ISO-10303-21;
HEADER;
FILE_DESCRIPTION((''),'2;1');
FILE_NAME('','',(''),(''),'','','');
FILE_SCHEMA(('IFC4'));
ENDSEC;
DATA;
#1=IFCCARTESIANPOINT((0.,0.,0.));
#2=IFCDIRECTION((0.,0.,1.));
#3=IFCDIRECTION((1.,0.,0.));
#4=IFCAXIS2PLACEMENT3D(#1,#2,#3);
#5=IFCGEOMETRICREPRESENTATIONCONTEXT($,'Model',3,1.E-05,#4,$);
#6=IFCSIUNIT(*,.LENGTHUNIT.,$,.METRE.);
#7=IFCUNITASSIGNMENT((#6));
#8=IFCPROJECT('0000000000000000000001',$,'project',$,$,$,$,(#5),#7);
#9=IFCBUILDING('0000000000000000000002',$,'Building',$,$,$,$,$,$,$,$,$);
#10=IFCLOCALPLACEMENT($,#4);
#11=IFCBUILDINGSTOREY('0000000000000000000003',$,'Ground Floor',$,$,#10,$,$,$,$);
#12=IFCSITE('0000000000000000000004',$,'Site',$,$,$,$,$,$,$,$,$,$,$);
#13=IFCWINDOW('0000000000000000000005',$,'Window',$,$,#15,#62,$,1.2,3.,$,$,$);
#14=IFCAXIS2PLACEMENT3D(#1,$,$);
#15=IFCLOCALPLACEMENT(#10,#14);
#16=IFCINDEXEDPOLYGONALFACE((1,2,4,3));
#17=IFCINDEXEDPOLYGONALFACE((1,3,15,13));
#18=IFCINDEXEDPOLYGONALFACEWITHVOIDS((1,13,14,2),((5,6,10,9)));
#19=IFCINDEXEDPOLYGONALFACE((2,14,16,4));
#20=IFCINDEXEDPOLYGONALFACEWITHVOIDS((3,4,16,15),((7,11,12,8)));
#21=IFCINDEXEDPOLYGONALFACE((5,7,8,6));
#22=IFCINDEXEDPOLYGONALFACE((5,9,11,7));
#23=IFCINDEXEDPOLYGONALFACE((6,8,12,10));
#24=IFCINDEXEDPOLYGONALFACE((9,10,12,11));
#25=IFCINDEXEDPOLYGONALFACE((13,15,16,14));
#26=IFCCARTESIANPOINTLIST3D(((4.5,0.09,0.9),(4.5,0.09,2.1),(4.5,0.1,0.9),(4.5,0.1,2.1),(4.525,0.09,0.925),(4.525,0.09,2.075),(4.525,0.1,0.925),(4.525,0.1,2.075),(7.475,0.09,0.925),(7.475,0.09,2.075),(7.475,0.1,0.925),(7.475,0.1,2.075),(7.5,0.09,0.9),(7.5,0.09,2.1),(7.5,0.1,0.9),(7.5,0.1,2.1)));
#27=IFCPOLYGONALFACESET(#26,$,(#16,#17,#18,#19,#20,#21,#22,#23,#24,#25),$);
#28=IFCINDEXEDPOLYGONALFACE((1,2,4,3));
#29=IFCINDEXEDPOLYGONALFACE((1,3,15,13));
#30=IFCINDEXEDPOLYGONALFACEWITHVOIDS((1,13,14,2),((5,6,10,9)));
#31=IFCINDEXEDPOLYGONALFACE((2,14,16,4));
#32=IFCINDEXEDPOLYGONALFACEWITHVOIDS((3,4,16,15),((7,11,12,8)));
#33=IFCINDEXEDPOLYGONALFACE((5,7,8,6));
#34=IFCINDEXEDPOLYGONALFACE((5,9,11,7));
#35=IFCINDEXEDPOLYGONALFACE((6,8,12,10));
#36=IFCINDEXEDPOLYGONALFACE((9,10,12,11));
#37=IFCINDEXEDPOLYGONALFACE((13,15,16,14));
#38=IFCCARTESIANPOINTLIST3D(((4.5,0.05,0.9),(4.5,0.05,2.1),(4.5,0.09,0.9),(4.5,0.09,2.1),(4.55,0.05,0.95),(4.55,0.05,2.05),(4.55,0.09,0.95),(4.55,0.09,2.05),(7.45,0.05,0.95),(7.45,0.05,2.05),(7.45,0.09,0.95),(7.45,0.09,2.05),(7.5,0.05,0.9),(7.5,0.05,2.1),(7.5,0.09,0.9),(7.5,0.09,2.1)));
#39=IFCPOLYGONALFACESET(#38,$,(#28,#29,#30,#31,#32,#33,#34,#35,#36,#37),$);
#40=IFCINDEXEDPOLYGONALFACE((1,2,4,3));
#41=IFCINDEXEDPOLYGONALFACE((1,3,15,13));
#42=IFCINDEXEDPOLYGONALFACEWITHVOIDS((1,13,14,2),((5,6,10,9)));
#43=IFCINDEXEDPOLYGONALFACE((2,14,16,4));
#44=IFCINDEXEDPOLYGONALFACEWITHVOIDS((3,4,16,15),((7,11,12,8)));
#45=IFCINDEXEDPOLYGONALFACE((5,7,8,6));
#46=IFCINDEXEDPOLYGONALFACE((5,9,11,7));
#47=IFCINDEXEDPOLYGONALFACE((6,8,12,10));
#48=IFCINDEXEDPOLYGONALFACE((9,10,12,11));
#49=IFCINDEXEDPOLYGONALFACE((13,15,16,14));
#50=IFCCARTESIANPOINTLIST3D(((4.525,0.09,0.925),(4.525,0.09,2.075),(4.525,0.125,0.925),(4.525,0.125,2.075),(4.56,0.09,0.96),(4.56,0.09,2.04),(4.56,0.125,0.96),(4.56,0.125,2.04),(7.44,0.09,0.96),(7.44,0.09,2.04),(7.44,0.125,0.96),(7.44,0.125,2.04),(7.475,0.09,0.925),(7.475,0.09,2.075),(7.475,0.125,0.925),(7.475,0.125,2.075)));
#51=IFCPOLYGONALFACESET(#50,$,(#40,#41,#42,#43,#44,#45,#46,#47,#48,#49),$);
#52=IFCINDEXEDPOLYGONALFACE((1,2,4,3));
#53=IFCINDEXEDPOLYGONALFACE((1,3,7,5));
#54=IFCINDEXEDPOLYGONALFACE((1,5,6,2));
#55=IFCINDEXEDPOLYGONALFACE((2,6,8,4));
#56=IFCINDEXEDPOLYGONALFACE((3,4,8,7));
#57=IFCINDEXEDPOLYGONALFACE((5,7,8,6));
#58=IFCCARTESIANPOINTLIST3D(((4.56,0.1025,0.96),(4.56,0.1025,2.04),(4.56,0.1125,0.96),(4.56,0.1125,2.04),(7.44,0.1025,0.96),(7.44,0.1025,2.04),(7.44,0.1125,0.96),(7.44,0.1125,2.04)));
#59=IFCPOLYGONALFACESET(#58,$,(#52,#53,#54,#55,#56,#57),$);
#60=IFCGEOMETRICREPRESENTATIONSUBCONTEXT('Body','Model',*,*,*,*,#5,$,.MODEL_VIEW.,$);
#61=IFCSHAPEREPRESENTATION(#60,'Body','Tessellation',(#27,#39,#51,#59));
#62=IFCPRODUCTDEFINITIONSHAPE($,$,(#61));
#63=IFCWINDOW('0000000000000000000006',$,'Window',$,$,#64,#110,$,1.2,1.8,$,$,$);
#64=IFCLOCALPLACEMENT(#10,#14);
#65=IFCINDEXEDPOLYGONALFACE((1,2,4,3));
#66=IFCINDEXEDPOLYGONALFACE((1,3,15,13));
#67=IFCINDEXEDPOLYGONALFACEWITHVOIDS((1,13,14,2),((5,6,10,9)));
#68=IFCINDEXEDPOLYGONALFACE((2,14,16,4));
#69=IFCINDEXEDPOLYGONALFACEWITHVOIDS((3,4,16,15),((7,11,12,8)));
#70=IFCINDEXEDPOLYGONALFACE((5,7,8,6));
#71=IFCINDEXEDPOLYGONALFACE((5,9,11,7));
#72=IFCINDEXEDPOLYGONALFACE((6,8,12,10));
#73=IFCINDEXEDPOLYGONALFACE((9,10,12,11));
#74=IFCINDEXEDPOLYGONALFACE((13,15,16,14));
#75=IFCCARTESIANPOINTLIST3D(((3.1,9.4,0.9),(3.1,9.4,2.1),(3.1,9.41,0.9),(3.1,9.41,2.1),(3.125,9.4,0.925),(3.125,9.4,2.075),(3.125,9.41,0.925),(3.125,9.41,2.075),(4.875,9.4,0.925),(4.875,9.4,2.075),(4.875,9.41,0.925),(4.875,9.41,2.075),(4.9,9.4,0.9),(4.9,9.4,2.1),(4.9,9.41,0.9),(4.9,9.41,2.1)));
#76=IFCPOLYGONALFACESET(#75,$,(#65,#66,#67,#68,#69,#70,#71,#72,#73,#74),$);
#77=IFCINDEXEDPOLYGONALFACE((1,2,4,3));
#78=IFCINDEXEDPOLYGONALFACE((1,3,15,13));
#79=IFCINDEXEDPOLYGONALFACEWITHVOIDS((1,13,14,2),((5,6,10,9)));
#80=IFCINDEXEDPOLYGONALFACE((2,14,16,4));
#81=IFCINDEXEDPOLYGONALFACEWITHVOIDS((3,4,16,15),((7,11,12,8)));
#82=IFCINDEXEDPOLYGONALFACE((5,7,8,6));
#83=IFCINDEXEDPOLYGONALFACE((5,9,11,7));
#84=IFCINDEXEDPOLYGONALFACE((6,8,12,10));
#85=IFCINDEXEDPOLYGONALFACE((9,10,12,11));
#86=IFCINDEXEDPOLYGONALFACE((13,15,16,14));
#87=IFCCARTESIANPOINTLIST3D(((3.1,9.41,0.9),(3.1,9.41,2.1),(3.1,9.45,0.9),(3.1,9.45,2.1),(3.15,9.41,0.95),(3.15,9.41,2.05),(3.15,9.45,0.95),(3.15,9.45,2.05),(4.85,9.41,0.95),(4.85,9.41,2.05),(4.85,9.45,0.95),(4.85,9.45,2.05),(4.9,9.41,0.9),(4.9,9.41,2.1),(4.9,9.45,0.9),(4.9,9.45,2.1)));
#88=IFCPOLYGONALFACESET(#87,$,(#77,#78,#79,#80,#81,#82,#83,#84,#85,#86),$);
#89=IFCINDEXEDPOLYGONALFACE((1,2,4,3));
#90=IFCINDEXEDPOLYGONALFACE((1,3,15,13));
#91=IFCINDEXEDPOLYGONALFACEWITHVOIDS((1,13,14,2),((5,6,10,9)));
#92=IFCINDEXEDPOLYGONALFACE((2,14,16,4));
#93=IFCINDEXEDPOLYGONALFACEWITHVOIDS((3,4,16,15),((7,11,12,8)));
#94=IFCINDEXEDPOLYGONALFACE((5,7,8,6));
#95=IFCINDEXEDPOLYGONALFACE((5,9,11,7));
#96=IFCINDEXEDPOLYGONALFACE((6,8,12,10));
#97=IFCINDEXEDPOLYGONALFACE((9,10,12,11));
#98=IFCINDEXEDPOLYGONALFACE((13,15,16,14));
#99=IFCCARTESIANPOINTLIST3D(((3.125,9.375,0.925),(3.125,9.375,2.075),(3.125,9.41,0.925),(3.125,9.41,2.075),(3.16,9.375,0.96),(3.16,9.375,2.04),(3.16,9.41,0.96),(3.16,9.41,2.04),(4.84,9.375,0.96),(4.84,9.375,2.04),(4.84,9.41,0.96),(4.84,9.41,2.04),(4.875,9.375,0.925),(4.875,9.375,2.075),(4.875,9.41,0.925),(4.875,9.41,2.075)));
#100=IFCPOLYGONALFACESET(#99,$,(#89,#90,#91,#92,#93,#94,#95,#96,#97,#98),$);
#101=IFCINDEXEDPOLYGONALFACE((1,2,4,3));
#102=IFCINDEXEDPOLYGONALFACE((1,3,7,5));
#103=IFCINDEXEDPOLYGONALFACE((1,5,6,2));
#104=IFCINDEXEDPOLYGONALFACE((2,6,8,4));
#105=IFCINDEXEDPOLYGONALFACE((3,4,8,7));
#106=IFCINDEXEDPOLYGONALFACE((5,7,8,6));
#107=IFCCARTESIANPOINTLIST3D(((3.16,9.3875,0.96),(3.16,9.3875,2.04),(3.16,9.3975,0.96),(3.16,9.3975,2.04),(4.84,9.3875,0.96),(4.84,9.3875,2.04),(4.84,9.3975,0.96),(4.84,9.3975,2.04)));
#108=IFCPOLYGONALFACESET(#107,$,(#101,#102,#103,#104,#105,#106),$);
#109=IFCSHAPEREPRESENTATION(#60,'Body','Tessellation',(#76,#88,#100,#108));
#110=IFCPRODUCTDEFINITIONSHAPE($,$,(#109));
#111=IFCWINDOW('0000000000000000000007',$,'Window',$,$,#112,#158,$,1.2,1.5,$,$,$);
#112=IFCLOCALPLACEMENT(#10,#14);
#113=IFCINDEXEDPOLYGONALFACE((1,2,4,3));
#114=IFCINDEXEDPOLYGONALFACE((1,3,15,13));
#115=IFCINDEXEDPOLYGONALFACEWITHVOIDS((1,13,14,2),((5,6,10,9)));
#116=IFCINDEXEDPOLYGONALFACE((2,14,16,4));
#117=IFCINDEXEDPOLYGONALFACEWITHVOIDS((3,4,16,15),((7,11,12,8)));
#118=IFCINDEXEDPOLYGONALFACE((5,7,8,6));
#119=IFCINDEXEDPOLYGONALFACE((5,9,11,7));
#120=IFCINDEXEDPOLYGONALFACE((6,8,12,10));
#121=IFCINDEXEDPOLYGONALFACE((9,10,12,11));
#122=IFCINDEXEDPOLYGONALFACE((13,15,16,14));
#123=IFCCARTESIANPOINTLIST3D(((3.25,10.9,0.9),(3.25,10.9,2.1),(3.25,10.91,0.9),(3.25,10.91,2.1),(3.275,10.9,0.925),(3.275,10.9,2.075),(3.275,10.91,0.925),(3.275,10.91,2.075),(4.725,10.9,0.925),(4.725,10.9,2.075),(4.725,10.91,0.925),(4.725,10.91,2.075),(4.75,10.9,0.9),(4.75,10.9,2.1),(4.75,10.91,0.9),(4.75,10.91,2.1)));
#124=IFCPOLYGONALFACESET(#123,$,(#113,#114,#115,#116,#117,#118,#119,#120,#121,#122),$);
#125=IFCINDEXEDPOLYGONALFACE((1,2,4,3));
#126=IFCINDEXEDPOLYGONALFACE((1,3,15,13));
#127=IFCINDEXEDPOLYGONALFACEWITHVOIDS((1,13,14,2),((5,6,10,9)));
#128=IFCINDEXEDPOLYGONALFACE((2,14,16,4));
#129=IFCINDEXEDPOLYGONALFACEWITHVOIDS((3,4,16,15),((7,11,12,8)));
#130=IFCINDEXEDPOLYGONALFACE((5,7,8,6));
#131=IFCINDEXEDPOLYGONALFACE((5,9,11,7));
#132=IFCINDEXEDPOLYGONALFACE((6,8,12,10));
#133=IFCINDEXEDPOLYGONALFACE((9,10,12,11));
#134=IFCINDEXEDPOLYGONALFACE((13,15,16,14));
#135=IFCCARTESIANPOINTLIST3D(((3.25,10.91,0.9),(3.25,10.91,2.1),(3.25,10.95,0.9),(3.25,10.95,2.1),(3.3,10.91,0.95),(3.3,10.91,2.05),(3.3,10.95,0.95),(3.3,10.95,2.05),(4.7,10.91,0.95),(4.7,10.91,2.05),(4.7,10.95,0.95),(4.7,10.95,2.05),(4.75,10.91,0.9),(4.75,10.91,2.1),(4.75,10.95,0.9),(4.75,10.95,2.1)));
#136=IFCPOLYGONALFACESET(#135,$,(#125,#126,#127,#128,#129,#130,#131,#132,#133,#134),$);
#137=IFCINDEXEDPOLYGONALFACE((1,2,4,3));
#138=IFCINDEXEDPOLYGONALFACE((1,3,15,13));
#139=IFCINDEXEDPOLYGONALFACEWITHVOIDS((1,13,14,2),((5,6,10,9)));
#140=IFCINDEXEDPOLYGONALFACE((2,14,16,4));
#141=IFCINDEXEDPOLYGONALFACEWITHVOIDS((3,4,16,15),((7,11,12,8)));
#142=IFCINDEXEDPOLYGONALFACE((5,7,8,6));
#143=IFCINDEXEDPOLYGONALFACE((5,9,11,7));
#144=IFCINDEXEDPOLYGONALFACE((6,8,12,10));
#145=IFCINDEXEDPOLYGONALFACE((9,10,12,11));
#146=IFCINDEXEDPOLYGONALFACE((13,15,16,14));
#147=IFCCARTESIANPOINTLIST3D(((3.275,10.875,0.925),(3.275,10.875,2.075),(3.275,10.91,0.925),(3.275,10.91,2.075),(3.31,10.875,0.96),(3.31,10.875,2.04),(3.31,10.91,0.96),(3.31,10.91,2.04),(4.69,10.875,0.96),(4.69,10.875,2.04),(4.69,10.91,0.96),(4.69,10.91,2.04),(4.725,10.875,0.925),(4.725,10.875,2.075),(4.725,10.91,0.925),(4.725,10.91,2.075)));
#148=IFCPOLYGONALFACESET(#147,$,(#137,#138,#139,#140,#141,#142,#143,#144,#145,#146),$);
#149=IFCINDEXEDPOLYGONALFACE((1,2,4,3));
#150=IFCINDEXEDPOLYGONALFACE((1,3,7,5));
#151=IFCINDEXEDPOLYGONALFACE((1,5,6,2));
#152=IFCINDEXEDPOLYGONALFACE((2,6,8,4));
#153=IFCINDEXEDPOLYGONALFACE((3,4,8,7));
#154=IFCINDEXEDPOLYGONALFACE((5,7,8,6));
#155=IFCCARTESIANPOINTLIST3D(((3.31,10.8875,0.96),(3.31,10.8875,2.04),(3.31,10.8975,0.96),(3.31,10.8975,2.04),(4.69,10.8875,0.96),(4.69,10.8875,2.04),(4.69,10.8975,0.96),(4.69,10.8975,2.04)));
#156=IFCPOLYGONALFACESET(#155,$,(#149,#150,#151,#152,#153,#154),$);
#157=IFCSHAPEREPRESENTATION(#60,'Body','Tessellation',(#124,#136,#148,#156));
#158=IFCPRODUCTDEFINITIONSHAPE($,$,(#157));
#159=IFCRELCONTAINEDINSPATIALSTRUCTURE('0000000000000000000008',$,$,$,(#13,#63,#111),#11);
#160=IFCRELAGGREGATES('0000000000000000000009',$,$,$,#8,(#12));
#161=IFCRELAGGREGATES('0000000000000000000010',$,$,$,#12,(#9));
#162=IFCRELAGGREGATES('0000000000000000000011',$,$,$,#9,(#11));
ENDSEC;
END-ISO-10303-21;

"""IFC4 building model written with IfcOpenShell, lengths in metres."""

from ifc_helpers import new_model, si_unit, frame, origin_with_axes, place, context, subcontext, project, spatial, line, indexed_curve, outline, extrude, element, save


model = new_model("IFC4")

# Units and contexts
model_context = context("Model", 3, precision=1e-05, world=origin_with_axes())
body_context = subcontext(model_context, "Body", "Model", "MODEL_VIEW")
ifc_project = project(units=[si_unit("LENGTHUNIT", "METRE")], contexts=[model_context])

# Site, building, storey
site = spatial("IfcSite", under=ifc_project, Name="Site")
building = spatial("IfcBuilding", under=site, Name="Building")
storey_placement = place(None, origin_with_axes())
storey = spatial("IfcBuildingStorey", under=building, at=storey_placement, Name="Ground Floor")

# Windows
window_1_placement = place(storey_placement, frame((4.5, 0.0, 0.9), z_axis=(0.0, 0.0, 1.0), x_axis=(1.0, 0.0, 0.0)))
element("IfcWindow", 1, at=window_1_placement, inside=storey, Name="Window", OverallHeight=1.2, OverallWidth=3.0, context=body_context, shape_type="SweptSolid", body=[
    extrude(outline(indexed_curve([(0.0, 0.0), (3.0, 0.0), (3.0, 1.2), (0.0, 1.2)], segments=[line(1, 2, 3, 4, 1)]), holes=[indexed_curve([(0.025, 0.025), (2.975, 0.025), (2.975, 1.175), (0.025, 1.175)], segments=[line(1, 2, 3, 4, 1)])]), frame((0.0, 0.09, 0.0), z_axis=(0.0, -1.0, 0.0), x_axis=(1.0, 0.0, 0.0)), (0.0, 0.0, -1.0), 0.01),
    extrude(outline(indexed_curve([(0.0, 0.0), (3.0, 0.0), (3.0, 1.2), (0.0, 1.2)], segments=[line(1, 2, 3, 4, 1)]), holes=[indexed_curve([(0.05, 0.05), (2.95, 0.05), (2.95, 1.15), (0.05, 1.15)], segments=[line(1, 2, 3, 4, 1)])]), frame((0.0, 0.05, 0.0), z_axis=(0.0, -1.0, 0.0), x_axis=(1.0, 0.0, 0.0)), (0.0, 0.0, -1.0), 0.04),
    extrude(outline(indexed_curve([(0.0, 0.0), (2.95, 0.0), (2.95, 1.15), (0.0, 1.15)], segments=[line(1, 2, 3, 4, 1)]), holes=[indexed_curve([(0.035, 0.035), (2.915, 0.035), (2.915, 1.115), (0.035, 1.115)], segments=[line(1, 2, 3, 4, 1)])]), frame((0.025, 0.09, 0.025), z_axis=(0.0, -1.0, 0.0), x_axis=(1.0, 0.0, 0.0)), (0.0, 0.0, -1.0), 0.035),
    extrude(outline(indexed_curve([(0.035, 0.035), (2.915, 0.035), (2.915, 1.115), (0.035, 1.115)], segments=[line(1, 2, 3, 4, 1)])), frame((0.025, 0.1025, 0.025), z_axis=(0.0, -1.0, 0.0), x_axis=(1.0, 0.0, 0.0)), (0.0, 0.0, -1.0), 0.01),
])
window_2_placement = place(storey_placement, frame((4.9, 9.5, 0.9), z_axis=(0.0, 0.0, 1.0), x_axis=(-1.0, 0.0, 0.0)))
element("IfcWindow", 2, at=window_2_placement, inside=storey, Name="Window", OverallHeight=1.2, OverallWidth=1.8, context=body_context, shape_type="SweptSolid", body=[
    extrude(outline(indexed_curve([(0.0, 0.0), (1.8, 0.0), (1.8, 1.2), (0.0, 1.2)], segments=[line(1, 2, 3, 4, 1)]), holes=[indexed_curve([(0.025, 0.025), (1.775, 0.025), (1.775, 1.175), (0.025, 1.175)], segments=[line(1, 2, 3, 4, 1)])]), frame((0.0, 0.09, 0.0), z_axis=(0.0, -1.0, 0.0), x_axis=(1.0, 0.0, 0.0)), (0.0, 0.0, -1.0), 0.01),
    extrude(outline(indexed_curve([(0.0, 0.0), (1.8, 0.0), (1.8, 1.2), (0.0, 1.2)], segments=[line(1, 2, 3, 4, 1)]), holes=[indexed_curve([(0.05, 0.05), (1.75, 0.05), (1.75, 1.15), (0.05, 1.15)], segments=[line(1, 2, 3, 4, 1)])]), frame((0.0, 0.05, 0.0), z_axis=(0.0, -1.0, 0.0), x_axis=(1.0, 0.0, 0.0)), (0.0, 0.0, -1.0), 0.04),
    extrude(outline(indexed_curve([(0.0, 0.0), (1.75, 0.0), (1.75, 1.15), (0.0, 1.15)], segments=[line(1, 2, 3, 4, 1)]), holes=[indexed_curve([(0.035, 0.035), (1.715, 0.035), (1.715, 1.115), (0.035, 1.115)], segments=[line(1, 2, 3, 4, 1)])]), frame((0.025, 0.09, 0.025), z_axis=(0.0, -1.0, 0.0), x_axis=(1.0, 0.0, 0.0)), (0.0, 0.0, -1.0), 0.035),
    extrude(outline(indexed_curve([(0.035, 0.035), (1.715, 0.035), (1.715, 1.115), (0.035, 1.115)], segments=[line(1, 2, 3, 4, 1)])), frame((0.025, 0.1025, 0.025), z_axis=(0.0, -1.0, 0.0), x_axis=(1.0, 0.0, 0.0)), (0.0, 0.0, -1.0), 0.01),
])
window_3_placement = place(storey_placement, frame((4.75, 11.0, 0.9), z_axis=(0.0, 0.0, 1.0), x_axis=(-1.0, 0.0, 0.0)))
element("IfcWindow", 3, at=window_3_placement, inside=storey, Name="Window", OverallHeight=1.2, OverallWidth=1.5, context=body_context, shape_type="SweptSolid", body=[
    extrude(outline(indexed_curve([(0.0, 0.0), (1.5, 0.0), (1.5, 1.2), (0.0, 1.2)], segments=[line(1, 2, 3, 4, 1)]), holes=[indexed_curve([(0.025, 0.025), (1.475, 0.025), (1.475, 1.175), (0.025, 1.175)], segments=[line(1, 2, 3, 4, 1)])]), frame((0.0, 0.09, 0.0), z_axis=(0.0, -1.0, 0.0), x_axis=(1.0, 0.0, 0.0)), (0.0, 0.0, -1.0), 0.01),
    extrude(outline(indexed_curve([(0.0, 0.0), (1.5, 0.0), (1.5, 1.2), (0.0, 1.2)], segments=[line(1, 2, 3, 4, 1)]), holes=[indexed_curve([(0.05, 0.05), (1.45, 0.05), (1.45, 1.15), (0.05, 1.15)], segments=[line(1, 2, 3, 4, 1)])]), frame((0.0, 0.05, 0.0), z_axis=(0.0, -1.0, 0.0), x_axis=(1.0, 0.0, 0.0)), (0.0, 0.0, -1.0), 0.04),
    extrude(outline(indexed_curve([(0.0, 0.0), (1.45, 0.0), (1.45, 1.15), (0.0, 1.15)], segments=[line(1, 2, 3, 4, 1)]), holes=[indexed_curve([(0.035, 0.035), (1.415, 0.035), (1.415, 1.115), (0.035, 1.115)], segments=[line(1, 2, 3, 4, 1)])]), frame((0.025, 0.09, 0.025), z_axis=(0.0, -1.0, 0.0), x_axis=(1.0, 0.0, 0.0)), (0.0, 0.0, -1.0), 0.035),
    extrude(outline(indexed_curve([(0.035, 0.035), (1.415, 0.035), (1.415, 1.115), (0.035, 1.115)], segments=[line(1, 2, 3, 4, 1)])), frame((0.025, 0.1025, 0.025), z_axis=(0.0, -1.0, 0.0), x_axis=(1.0, 0.0, 0.0)), (0.0, 0.0, -1.0), 0.01),
])

save(model, "model.ifc")
